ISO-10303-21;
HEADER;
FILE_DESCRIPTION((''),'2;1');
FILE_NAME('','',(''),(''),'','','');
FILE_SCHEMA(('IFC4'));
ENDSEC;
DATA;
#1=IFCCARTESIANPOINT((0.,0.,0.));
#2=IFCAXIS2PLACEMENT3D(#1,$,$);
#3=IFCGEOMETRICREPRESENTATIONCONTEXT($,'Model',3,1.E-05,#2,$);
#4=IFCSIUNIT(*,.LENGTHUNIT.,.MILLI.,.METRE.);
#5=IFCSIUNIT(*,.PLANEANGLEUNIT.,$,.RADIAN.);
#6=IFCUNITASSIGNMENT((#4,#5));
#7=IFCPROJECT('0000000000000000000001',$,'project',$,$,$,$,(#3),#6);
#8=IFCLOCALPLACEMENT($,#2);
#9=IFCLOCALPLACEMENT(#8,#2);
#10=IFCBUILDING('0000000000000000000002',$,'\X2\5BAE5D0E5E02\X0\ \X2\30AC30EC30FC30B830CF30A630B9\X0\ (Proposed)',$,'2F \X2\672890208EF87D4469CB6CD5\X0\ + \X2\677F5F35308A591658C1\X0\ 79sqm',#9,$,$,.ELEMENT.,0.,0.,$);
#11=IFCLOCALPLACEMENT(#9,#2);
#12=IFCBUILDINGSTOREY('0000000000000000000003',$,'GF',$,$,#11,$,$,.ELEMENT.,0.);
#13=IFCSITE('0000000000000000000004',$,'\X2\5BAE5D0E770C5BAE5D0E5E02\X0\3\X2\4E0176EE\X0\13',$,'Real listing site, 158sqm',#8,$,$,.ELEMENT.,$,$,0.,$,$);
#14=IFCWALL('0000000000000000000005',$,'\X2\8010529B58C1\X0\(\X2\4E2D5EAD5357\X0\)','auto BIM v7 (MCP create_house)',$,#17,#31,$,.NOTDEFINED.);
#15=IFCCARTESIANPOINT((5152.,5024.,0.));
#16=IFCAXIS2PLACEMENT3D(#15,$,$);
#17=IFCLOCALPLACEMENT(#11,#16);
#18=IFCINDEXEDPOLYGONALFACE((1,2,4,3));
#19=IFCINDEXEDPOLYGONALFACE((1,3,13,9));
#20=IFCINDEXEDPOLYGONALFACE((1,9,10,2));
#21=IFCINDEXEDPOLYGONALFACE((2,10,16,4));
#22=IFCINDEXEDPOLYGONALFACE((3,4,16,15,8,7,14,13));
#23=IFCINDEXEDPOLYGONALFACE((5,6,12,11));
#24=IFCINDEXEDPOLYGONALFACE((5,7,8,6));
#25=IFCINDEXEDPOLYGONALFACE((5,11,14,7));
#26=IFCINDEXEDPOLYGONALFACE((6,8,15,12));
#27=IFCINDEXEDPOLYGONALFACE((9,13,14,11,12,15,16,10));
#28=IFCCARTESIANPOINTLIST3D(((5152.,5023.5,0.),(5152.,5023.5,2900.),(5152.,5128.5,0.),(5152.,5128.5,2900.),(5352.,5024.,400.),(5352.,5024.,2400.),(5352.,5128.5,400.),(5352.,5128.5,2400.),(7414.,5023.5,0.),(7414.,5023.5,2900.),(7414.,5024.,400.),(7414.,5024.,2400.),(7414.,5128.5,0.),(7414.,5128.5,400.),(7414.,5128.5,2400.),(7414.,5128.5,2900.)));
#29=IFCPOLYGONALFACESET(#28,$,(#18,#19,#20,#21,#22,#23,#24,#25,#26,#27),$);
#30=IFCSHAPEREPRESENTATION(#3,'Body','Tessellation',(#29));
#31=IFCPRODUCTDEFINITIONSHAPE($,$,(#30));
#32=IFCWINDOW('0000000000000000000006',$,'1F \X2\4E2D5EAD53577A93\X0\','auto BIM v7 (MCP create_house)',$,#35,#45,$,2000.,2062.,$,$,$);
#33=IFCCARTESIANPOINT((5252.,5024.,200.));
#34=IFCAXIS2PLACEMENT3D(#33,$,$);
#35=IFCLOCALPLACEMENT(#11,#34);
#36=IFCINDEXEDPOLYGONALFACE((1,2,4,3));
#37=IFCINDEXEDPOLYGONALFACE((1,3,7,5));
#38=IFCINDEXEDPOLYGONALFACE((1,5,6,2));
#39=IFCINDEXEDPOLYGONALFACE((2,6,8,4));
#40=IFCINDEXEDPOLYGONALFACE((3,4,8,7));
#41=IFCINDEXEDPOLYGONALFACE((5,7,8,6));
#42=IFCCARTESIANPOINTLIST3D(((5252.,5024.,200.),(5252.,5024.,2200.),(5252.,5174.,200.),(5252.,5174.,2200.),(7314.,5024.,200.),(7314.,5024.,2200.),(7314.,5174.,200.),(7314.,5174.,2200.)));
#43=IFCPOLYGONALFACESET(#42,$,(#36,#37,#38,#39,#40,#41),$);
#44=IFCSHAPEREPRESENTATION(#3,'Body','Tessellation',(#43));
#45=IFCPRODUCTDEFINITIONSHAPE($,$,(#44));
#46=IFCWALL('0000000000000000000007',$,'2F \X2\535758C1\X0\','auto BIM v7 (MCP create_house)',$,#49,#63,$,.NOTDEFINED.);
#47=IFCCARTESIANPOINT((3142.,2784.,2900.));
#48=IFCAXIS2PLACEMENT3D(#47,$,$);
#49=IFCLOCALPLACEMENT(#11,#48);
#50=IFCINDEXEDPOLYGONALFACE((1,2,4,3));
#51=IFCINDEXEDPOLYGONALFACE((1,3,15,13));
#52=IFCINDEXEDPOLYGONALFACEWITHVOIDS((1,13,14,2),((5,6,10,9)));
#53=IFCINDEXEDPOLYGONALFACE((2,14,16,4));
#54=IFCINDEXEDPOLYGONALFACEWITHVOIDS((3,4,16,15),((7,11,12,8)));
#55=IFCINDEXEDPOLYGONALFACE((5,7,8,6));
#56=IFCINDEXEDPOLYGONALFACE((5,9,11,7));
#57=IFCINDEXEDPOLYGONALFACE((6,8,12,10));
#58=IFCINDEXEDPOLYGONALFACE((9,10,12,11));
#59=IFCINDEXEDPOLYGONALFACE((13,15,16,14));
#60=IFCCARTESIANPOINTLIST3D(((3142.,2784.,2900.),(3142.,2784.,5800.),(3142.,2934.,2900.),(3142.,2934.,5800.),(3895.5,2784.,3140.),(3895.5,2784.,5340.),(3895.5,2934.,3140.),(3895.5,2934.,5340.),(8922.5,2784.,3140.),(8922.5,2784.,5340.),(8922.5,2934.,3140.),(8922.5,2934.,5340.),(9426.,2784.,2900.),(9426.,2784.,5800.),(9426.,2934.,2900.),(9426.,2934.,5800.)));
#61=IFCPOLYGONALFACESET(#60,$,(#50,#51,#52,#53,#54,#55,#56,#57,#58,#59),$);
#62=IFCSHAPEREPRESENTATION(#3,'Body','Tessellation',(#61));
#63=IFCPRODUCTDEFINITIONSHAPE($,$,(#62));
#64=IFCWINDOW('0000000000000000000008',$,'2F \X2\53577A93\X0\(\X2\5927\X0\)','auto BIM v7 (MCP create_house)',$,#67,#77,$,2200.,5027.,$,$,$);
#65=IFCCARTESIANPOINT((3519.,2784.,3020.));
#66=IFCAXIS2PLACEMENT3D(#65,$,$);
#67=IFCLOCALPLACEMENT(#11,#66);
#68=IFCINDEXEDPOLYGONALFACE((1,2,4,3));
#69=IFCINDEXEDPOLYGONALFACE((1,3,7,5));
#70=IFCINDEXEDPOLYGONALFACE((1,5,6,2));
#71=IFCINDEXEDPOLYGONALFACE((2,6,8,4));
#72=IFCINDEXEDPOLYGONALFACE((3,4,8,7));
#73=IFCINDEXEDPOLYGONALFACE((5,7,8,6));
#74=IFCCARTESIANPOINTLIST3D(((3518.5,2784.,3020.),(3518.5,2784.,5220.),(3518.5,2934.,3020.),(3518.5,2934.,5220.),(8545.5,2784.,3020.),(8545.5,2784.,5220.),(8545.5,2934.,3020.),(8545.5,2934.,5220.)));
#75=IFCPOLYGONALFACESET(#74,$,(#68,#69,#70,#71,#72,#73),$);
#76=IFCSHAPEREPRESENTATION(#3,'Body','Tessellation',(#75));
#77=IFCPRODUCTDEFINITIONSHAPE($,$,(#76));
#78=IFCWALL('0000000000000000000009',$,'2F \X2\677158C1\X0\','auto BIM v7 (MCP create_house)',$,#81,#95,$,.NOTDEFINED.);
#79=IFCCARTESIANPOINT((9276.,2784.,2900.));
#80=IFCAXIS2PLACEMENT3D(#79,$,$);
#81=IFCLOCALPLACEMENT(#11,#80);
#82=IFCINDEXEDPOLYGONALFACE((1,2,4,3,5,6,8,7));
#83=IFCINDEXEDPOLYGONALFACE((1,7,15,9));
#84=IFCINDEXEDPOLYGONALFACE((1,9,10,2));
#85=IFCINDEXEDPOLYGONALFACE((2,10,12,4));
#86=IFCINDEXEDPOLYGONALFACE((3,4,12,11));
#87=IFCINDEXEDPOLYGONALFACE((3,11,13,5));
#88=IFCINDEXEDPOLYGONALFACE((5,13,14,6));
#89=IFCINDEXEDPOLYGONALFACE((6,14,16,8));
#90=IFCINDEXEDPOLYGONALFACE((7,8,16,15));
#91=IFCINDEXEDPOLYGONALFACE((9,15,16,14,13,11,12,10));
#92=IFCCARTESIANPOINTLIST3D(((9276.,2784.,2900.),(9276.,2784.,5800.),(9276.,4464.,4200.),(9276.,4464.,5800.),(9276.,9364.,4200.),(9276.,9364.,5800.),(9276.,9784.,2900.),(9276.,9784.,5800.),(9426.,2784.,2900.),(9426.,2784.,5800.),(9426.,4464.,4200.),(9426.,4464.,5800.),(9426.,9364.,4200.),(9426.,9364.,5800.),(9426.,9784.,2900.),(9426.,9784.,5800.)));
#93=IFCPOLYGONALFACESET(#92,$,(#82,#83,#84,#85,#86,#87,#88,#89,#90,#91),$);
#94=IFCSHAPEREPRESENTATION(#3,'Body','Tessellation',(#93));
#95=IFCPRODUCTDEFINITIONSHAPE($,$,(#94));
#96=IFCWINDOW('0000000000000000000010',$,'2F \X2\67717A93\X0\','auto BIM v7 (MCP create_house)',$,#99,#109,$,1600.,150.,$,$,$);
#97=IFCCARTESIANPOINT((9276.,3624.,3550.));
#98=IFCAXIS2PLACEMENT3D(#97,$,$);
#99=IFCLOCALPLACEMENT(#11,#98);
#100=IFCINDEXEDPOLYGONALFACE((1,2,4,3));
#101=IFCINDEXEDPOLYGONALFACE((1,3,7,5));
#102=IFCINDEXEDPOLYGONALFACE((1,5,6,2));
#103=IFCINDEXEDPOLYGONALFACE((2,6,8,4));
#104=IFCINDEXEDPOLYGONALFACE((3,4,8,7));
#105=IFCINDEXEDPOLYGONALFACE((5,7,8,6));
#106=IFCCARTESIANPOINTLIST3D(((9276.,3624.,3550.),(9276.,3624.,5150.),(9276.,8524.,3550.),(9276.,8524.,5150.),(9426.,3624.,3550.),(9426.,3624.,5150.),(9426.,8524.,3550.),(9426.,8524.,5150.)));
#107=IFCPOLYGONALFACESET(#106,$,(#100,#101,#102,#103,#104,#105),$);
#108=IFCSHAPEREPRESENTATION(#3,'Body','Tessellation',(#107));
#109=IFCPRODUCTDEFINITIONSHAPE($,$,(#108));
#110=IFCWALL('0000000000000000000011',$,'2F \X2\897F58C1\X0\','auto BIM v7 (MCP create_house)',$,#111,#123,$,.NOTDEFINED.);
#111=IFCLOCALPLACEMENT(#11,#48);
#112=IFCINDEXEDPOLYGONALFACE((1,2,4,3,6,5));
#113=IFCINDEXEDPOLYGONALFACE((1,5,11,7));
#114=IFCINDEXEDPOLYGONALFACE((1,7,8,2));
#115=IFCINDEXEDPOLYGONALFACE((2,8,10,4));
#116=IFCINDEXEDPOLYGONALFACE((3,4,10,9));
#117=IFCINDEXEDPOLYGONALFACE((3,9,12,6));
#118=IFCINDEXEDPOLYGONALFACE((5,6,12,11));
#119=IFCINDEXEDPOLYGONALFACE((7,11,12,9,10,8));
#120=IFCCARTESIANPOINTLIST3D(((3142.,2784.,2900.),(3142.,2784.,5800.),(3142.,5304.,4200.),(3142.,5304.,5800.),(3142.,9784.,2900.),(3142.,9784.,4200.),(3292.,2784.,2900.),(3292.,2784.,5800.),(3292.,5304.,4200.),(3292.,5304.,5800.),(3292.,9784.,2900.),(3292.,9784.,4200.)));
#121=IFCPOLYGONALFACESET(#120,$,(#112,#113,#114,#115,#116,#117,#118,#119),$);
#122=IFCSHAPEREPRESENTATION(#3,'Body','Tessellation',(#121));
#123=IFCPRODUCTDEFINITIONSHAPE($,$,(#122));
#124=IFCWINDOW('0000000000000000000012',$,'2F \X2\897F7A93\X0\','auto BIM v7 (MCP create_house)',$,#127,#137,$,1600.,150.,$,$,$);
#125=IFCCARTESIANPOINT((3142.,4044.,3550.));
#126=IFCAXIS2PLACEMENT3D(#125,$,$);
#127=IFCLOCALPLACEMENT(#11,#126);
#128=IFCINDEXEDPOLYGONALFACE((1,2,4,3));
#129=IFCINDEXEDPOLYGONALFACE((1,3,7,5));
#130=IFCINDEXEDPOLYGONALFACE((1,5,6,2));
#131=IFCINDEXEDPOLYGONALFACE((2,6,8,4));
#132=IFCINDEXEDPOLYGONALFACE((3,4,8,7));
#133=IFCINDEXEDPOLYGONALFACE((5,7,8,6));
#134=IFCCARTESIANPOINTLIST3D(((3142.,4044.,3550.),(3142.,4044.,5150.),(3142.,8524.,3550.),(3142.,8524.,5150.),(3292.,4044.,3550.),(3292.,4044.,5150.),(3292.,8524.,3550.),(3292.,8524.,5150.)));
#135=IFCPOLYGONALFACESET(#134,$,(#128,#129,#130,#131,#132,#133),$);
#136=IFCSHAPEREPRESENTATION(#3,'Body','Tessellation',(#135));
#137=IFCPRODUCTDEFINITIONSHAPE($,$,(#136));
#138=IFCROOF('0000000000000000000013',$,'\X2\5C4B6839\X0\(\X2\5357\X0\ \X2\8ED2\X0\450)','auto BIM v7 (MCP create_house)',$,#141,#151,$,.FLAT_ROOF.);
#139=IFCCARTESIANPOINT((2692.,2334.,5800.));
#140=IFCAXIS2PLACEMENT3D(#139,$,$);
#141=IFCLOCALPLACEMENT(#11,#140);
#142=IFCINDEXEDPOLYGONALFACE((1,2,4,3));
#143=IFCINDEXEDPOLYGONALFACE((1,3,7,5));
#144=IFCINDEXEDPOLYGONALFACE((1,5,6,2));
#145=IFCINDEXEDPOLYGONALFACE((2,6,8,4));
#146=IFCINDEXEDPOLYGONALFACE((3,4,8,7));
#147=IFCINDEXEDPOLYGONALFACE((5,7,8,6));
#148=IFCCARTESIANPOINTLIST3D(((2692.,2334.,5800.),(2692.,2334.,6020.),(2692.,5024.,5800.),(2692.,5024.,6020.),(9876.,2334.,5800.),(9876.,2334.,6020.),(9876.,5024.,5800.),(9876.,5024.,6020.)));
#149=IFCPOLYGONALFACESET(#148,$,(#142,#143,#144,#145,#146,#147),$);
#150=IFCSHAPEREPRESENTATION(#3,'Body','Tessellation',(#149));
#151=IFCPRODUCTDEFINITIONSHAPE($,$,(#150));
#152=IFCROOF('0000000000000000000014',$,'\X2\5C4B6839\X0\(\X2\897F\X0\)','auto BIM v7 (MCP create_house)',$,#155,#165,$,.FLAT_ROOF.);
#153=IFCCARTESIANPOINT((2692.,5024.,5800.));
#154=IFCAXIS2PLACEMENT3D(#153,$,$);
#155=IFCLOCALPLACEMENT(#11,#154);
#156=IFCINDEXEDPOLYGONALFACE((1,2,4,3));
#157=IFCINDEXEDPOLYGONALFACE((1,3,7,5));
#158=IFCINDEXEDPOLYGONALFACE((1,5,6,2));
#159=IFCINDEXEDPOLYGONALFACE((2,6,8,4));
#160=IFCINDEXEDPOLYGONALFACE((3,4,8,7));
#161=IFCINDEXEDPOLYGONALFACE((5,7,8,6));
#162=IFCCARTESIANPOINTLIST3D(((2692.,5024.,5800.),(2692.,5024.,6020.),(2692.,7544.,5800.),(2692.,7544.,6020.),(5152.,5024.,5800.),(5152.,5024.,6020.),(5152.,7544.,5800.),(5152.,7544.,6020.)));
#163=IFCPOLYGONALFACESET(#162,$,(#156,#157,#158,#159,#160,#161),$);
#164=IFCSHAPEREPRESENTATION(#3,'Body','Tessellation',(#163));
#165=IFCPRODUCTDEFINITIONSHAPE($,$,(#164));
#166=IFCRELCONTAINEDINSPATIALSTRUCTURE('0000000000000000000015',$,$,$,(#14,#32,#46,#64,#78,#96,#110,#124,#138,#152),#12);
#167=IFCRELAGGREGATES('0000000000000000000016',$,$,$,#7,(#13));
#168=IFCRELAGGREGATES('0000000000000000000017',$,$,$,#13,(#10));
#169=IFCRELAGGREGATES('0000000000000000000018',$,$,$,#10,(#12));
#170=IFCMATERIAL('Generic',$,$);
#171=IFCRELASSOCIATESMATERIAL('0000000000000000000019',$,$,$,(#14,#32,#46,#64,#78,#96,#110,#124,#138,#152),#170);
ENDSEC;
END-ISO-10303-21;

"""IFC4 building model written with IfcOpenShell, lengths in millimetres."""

from ifc_helpers import new_model, si_unit, frame, frame_2d, origin, place, context, project, spatial, rectangle, extrude, material, element, fill, save


model = new_model("IFC4")

# Units and contexts
model_context = context("Model", 3, precision=1e-05, world=origin())
ifc_project = project(units=[si_unit("LENGTHUNIT", "METRE", prefix="MILLI"), si_unit("PLANEANGLEUNIT", "RADIAN")], contexts=[model_context])

# Site, building, storey
site_placement = place(None, origin())
site = spatial("IfcSite", under=ifc_project, at=site_placement, Name="宮崎県宮崎市3丁目13", ObjectType="Real listing site, 158sqm", CompositionType="ELEMENT", RefElevation=0.0)
building_placement = place(site_placement, origin())
building = spatial("IfcBuilding", under=site, at=building_placement, Name="宮崎市 ガレージハウス (Proposed)", ObjectType="2F 木造軸組構法 + 板張り外壁 79sqm", CompositionType="ELEMENT", ElevationOfRefHeight=0.0, ElevationOfTerrain=0.0)
storey_placement = place(building_placement, origin())
storey = spatial("IfcBuildingStorey", under=building, at=storey_placement, Name="GF", CompositionType="ELEMENT", Elevation=0.0)

# Shared definitions
ifc_material = material(Name="Generic")

# Wall, opening, window
wall_1_placement = place(storey_placement, frame((5152.0, 5024.0, 0.0)))
wall_1 = element("IfcWall", 1, at=wall_1_placement, inside=storey, material=ifc_material, Name="耐力壁(中庭南)", Description="auto BIM v7 (MCP create_house)", PredefinedType="NOTDEFINED", context=model_context, shape_type="SweptSolid", body=[
    extrude(rectangle(XDim=2262.0, YDim=105.0, at=frame_2d((1131.0, 52.0))), frame((5152.0, 5024.0, 0.0)), (0.0, 0.0, 1.0), 2900.0),
])
opening_1_placement = place(storey_placement, frame((5252.0, 5024.0, 200.0)))
opening_1 = element("IfcOpeningElement", 2, at=opening_1_placement, cuts=wall_1, PredefinedType="NOTDEFINED", context=model_context, shape_type="SweptSolid", body=[
    extrude(rectangle(XDim=2062.0, YDim=150.0, at=frame_2d((1031.0, 75.0))), frame((5252.0, 5024.0, 200.0)), (0.0, 0.0, 1.0), 2000.0),
])
window_1_placement = place(storey_placement, frame((5252.0, 5024.0, 200.0)))
window_1 = element("IfcWindow", 3, at=window_1_placement, inside=storey, material=ifc_material, Name="1F 中庭南窓", Description="auto BIM v7 (MCP create_house)", OverallHeight=2000.0, OverallWidth=2062.0, context=model_context, shape_type="SweptSolid", body=[
    extrude(rectangle(XDim=2062.0, YDim=150.0, at=frame_2d((1031.0, 75.0))), frame((5252.0, 5024.0, 200.0)), (0.0, 0.0, 1.0), 2000.0),
])
fill(opening_1, window_1)

# Walls, openings, windows
wall_2_placement = place(storey_placement, frame((3142.0, 2784.0, 2900.0)))
wall_2 = element("IfcWall", 4, at=wall_2_placement, inside=storey, material=ifc_material, Name="2F 南壁", Description="auto BIM v7 (MCP create_house)", PredefinedType="NOTDEFINED", context=model_context, shape_type="SweptSolid", body=[
    extrude(rectangle(XDim=6284.0, YDim=150.0, at=frame_2d((3142.0, 75.0))), frame((3142.0, 2784.0, 2900.0)), (0.0, 0.0, 1.0), 2900.0),
])
opening_2_placement = place(storey_placement, frame((3519.0, 2784.0, 3020.0)))
opening_2 = element("IfcOpeningElement", 5, at=opening_2_placement, cuts=wall_2, PredefinedType="NOTDEFINED", context=model_context, shape_type="SweptSolid", body=[
    extrude(rectangle(XDim=5027.0, YDim=150.0, at=frame_2d((2513.0, 75.0))), frame((3519.0, 2784.0, 3020.0)), (0.0, 0.0, 1.0), 2200.0),
])
window_2_placement = place(storey_placement, frame((3519.0, 2784.0, 3020.0)))
window_2 = element("IfcWindow", 6, at=window_2_placement, inside=storey, material=ifc_material, Name="2F 南窓(大)", Description="auto BIM v7 (MCP create_house)", OverallHeight=2200.0, OverallWidth=5027.0, context=model_context, shape_type="SweptSolid", body=[
    extrude(rectangle(XDim=5027.0, YDim=150.0, at=frame_2d((2513.0, 75.0))), frame((3519.0, 2784.0, 3020.0)), (0.0, 0.0, 1.0), 2200.0),
])
fill(opening_2, window_2)
wall_3_placement = place(storey_placement, frame((9276.0, 2784.0, 2900.0)))
wall_3 = element("IfcWall", 7, at=wall_3_placement, inside=storey, material=ifc_material, Name="2F 東壁", Description="auto BIM v7 (MCP create_house)", PredefinedType="NOTDEFINED", context=model_context, shape_type="SweptSolid", body=[
    extrude(rectangle(XDim=150.0, YDim=7000.0, at=frame_2d((75.0, 3500.0))), frame((9276.0, 2784.0, 2900.0)), (0.0, 0.0, 1.0), 2900.0),
])
opening_3_placement = place(storey_placement, frame((9276.0, 3624.0, 3550.0)))
opening_3 = element("IfcOpeningElement", 8, at=opening_3_placement, cuts=wall_3, PredefinedType="NOTDEFINED", context=model_context, shape_type="SweptSolid", body=[
    extrude(rectangle(XDim=150.0, YDim=4900.0, at=frame_2d((75.0, 2450.0))), frame((9276.0, 3624.0, 3550.0)), (0.0, 0.0, 1.0), 1600.0),
])
window_3_placement = place(storey_placement, frame((9276.0, 3624.0, 3550.0)))
window_3 = element("IfcWindow", 9, at=window_3_placement, inside=storey, material=ifc_material, Name="2F 東窓", Description="auto BIM v7 (MCP create_house)", OverallHeight=1600.0, OverallWidth=150.0, context=model_context, shape_type="SweptSolid", body=[
    extrude(rectangle(XDim=150.0, YDim=4900.0, at=frame_2d((75.0, 2450.0))), frame((9276.0, 3624.0, 3550.0)), (0.0, 0.0, 1.0), 1600.0),
])
fill(opening_3, window_3)
wall_4_placement = place(storey_placement, frame((3142.0, 2784.0, 2900.0)))
wall_4 = element("IfcWall", 10, at=wall_4_placement, inside=storey, material=ifc_material, Name="2F 西壁", Description="auto BIM v7 (MCP create_house)", PredefinedType="NOTDEFINED", context=model_context, shape_type="SweptSolid", body=[
    extrude(rectangle(XDim=150.0, YDim=7000.0, at=frame_2d((75.0, 3500.0))), frame((3142.0, 2784.0, 2900.0)), (0.0, 0.0, 1.0), 2900.0),
])
opening_4_placement = place(storey_placement, frame((3142.0, 4044.0, 3550.0)))
opening_4 = element("IfcOpeningElement", 11, at=opening_4_placement, cuts=wall_4, PredefinedType="NOTDEFINED", context=model_context, shape_type="SweptSolid", body=[
    extrude(rectangle(XDim=150.0, YDim=4480.0, at=frame_2d((75.0, 2240.0))), frame((3142.0, 4044.0, 3550.0)), (0.0, 0.0, 1.0), 1600.0),
])
window_4_placement = place(storey_placement, frame((3142.0, 4044.0, 3550.0)))
window_4 = element("IfcWindow", 12, at=window_4_placement, inside=storey, material=ifc_material, Name="2F 西窓", Description="auto BIM v7 (MCP create_house)", OverallHeight=1600.0, OverallWidth=150.0, context=model_context, shape_type="SweptSolid", body=[
    extrude(rectangle(XDim=150.0, YDim=4480.0, at=frame_2d((75.0, 2240.0))), frame((3142.0, 4044.0, 3550.0)), (0.0, 0.0, 1.0), 1600.0),
])
fill(opening_4, window_4)

# Roofs
roof_1_placement = place(storey_placement, frame((2692.0, 2334.0, 5800.0)))
element("IfcRoof", 13, at=roof_1_placement, inside=storey, material=ifc_material, Name="屋根(南 軒450)", Description="auto BIM v7 (MCP create_house)", PredefinedType="FLAT_ROOF", context=model_context, shape_type="SweptSolid", body=[
    extrude(rectangle(XDim=7184.0, YDim=2690.0, at=frame_2d((3592.0, 1345.0))), frame((2692.0, 2334.0, 5800.0)), (0.0, 0.0, 1.0), 220.0),
])
roof_2_placement = place(storey_placement, frame((2692.0, 5024.0, 5800.0)))
element("IfcRoof", 14, at=roof_2_placement, inside=storey, material=ifc_material, Name="屋根(西)", Description="auto BIM v7 (MCP create_house)", PredefinedType="FLAT_ROOF", context=model_context, shape_type="SweptSolid", body=[
    extrude(rectangle(XDim=2460.0, YDim=2520.0, at=frame_2d((1230.0, 1260.0))), frame((2692.0, 5024.0, 5800.0)), (0.0, 0.0, 1.0), 220.0),
])

save(model, "model.ifc")
